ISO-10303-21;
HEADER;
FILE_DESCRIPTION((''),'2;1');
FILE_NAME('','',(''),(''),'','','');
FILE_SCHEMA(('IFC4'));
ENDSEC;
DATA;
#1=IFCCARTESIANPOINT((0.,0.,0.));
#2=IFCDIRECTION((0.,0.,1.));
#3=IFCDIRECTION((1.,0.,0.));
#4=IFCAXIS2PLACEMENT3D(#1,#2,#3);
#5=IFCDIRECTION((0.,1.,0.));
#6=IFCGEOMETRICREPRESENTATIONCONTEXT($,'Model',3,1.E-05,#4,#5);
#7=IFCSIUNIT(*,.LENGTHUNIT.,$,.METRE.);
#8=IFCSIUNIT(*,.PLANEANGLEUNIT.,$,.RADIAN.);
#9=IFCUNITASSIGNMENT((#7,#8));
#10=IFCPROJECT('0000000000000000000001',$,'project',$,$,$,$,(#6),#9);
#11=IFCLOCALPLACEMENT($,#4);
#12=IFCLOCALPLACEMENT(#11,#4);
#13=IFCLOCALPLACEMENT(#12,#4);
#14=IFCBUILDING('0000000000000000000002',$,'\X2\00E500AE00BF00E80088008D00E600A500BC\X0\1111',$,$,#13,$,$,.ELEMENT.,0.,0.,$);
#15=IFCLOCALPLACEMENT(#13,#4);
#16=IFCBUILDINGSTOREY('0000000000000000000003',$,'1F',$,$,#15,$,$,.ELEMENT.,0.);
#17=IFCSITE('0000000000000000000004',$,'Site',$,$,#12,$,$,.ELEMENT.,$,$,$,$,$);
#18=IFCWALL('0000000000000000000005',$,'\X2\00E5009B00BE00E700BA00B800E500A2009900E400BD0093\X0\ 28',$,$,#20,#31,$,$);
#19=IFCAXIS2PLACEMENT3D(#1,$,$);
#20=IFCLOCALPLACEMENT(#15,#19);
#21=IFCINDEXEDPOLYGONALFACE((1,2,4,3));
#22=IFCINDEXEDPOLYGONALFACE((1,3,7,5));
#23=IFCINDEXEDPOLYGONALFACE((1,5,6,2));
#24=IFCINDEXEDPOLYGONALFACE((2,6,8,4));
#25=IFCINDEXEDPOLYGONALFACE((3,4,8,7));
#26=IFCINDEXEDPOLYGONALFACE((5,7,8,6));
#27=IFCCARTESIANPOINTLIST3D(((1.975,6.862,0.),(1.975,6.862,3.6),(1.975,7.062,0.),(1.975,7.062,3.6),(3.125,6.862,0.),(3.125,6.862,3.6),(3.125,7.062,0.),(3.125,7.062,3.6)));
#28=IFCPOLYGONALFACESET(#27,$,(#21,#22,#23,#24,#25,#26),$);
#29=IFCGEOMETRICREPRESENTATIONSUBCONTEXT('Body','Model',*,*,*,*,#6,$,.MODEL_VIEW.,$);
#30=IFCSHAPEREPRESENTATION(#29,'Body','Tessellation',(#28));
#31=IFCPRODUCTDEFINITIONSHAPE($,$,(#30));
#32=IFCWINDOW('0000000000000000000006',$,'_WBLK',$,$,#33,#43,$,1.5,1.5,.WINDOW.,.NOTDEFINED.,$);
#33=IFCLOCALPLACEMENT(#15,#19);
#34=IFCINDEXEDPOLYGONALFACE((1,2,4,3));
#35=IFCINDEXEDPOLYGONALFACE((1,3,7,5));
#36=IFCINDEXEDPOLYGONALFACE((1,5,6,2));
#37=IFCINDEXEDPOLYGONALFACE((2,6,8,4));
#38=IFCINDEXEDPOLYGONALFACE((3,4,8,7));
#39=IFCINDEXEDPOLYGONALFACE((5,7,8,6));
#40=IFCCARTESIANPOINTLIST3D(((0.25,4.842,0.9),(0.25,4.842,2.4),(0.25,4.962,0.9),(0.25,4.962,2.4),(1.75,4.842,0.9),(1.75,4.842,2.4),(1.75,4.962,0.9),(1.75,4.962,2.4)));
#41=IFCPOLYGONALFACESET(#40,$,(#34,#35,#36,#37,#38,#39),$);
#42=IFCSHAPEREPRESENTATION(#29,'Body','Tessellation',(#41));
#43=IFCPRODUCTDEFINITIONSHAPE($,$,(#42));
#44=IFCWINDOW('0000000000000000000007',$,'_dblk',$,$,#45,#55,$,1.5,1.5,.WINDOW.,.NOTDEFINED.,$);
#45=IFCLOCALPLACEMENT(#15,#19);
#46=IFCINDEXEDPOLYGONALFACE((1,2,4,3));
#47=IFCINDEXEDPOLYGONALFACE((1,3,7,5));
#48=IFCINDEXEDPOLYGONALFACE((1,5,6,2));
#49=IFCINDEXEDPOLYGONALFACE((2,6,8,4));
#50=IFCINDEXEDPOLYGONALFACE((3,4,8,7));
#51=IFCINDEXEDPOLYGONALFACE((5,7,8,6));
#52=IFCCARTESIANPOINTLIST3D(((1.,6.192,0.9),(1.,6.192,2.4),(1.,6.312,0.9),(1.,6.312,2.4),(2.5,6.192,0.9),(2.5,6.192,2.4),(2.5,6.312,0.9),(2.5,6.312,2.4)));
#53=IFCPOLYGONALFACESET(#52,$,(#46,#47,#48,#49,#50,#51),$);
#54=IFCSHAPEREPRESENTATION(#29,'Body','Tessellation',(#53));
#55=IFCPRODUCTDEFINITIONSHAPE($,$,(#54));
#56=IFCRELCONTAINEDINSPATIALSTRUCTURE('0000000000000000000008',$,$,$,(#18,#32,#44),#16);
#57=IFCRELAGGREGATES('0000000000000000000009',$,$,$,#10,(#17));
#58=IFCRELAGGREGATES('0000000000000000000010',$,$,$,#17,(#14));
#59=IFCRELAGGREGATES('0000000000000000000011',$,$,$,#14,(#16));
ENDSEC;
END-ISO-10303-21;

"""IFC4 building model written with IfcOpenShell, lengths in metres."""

from ifc_helpers import new_model, si_unit, direction, frame, frame_2d, origin_with_axes, place, context, subcontext, project, spatial, rectangle, extrude, element, save


model = new_model("IFC4")

# Units and contexts
model_context = context("Model", 3, precision=1e-05, world=origin_with_axes(), true_north=direction((0.0, 1.0, 0.0)))
body_context = subcontext(model_context, "Body", "Model", "MODEL_VIEW")
ifc_project = project(units=[si_unit("LENGTHUNIT", "METRE"), si_unit("PLANEANGLEUNIT", "RADIAN")], contexts=[model_context])

# Site, building, storey
placement = place(None, origin_with_axes())
site_placement = place(placement, origin_with_axes())
site = spatial("IfcSite", under=ifc_project, at=site_placement, Name="Site", CompositionType="ELEMENT")
building_placement = place(site_placement, origin_with_axes())
building = spatial("IfcBuilding", under=site, at=building_placement, Name="å®¿è\u0088\u008dæ¥¼1111", CompositionType="ELEMENT", ElevationOfRefHeight=0.0, ElevationOfTerrain=0.0)
storey_placement = place(building_placement, origin_with_axes())
storey = spatial("IfcBuildingStorey", under=building, at=storey_placement, Name="1F", CompositionType="ELEMENT", Elevation=0.0)

# Wall
wall_1_placement = place(storey_placement, frame((2.55, 6.962, 0.0), z_axis=(0.0, 0.0, 1.0), x_axis=(-1.0, 0.0, 0.0)))
element("IfcWall", 1, at=wall_1_placement, inside=storey, Name="å\u009b¾çº¸å¢\u0099ä½\u0093 28", context=body_context, shape_type="SweptSolid", body=[
    extrude(rectangle(XDim=1.15, YDim=0.2, at=frame_2d((0.0, 0.0), x_axis=(1.0, 0.0, 0.0))), frame((0.0, 0.0, 0.0), z_axis=(0.0, 0.0, 1.0)), (0.0, 0.0, 1.0), 3.6),
])

# Windows
for number, where, z_axis, x_axis, name in (
    (2, (1.0, 4.902, 0.9), (0.0, 0.0, 1.0), (1.0, 0.0, 0.0), "_WBLK"),
    (3, (1.75, 6.252, 0.9), (0.0, 0.0, 1.0), (1.0, 0.0, 0.0), "_dblk"),
):
    element("IfcWindow", number, at=place(storey_placement, frame(where, z_axis=z_axis, x_axis=x_axis)), inside=storey, Name=name, OverallHeight=1.5, OverallWidth=1.5, PartitioningType="NOTDEFINED", PredefinedType="WINDOW", context=body_context, shape_type="SweptSolid", body=[
        extrude(rectangle(XDim=1.5, YDim=0.12, at=frame_2d((0.0, 0.0), x_axis=(1.0, 0.0, 0.0))), frame((0.0, 0.0, 0.0), z_axis=(0.0, 0.0, 1.0)), (0.0, 0.0, 1.0), 1.5),
    ])

save(model, "model.ifc")
